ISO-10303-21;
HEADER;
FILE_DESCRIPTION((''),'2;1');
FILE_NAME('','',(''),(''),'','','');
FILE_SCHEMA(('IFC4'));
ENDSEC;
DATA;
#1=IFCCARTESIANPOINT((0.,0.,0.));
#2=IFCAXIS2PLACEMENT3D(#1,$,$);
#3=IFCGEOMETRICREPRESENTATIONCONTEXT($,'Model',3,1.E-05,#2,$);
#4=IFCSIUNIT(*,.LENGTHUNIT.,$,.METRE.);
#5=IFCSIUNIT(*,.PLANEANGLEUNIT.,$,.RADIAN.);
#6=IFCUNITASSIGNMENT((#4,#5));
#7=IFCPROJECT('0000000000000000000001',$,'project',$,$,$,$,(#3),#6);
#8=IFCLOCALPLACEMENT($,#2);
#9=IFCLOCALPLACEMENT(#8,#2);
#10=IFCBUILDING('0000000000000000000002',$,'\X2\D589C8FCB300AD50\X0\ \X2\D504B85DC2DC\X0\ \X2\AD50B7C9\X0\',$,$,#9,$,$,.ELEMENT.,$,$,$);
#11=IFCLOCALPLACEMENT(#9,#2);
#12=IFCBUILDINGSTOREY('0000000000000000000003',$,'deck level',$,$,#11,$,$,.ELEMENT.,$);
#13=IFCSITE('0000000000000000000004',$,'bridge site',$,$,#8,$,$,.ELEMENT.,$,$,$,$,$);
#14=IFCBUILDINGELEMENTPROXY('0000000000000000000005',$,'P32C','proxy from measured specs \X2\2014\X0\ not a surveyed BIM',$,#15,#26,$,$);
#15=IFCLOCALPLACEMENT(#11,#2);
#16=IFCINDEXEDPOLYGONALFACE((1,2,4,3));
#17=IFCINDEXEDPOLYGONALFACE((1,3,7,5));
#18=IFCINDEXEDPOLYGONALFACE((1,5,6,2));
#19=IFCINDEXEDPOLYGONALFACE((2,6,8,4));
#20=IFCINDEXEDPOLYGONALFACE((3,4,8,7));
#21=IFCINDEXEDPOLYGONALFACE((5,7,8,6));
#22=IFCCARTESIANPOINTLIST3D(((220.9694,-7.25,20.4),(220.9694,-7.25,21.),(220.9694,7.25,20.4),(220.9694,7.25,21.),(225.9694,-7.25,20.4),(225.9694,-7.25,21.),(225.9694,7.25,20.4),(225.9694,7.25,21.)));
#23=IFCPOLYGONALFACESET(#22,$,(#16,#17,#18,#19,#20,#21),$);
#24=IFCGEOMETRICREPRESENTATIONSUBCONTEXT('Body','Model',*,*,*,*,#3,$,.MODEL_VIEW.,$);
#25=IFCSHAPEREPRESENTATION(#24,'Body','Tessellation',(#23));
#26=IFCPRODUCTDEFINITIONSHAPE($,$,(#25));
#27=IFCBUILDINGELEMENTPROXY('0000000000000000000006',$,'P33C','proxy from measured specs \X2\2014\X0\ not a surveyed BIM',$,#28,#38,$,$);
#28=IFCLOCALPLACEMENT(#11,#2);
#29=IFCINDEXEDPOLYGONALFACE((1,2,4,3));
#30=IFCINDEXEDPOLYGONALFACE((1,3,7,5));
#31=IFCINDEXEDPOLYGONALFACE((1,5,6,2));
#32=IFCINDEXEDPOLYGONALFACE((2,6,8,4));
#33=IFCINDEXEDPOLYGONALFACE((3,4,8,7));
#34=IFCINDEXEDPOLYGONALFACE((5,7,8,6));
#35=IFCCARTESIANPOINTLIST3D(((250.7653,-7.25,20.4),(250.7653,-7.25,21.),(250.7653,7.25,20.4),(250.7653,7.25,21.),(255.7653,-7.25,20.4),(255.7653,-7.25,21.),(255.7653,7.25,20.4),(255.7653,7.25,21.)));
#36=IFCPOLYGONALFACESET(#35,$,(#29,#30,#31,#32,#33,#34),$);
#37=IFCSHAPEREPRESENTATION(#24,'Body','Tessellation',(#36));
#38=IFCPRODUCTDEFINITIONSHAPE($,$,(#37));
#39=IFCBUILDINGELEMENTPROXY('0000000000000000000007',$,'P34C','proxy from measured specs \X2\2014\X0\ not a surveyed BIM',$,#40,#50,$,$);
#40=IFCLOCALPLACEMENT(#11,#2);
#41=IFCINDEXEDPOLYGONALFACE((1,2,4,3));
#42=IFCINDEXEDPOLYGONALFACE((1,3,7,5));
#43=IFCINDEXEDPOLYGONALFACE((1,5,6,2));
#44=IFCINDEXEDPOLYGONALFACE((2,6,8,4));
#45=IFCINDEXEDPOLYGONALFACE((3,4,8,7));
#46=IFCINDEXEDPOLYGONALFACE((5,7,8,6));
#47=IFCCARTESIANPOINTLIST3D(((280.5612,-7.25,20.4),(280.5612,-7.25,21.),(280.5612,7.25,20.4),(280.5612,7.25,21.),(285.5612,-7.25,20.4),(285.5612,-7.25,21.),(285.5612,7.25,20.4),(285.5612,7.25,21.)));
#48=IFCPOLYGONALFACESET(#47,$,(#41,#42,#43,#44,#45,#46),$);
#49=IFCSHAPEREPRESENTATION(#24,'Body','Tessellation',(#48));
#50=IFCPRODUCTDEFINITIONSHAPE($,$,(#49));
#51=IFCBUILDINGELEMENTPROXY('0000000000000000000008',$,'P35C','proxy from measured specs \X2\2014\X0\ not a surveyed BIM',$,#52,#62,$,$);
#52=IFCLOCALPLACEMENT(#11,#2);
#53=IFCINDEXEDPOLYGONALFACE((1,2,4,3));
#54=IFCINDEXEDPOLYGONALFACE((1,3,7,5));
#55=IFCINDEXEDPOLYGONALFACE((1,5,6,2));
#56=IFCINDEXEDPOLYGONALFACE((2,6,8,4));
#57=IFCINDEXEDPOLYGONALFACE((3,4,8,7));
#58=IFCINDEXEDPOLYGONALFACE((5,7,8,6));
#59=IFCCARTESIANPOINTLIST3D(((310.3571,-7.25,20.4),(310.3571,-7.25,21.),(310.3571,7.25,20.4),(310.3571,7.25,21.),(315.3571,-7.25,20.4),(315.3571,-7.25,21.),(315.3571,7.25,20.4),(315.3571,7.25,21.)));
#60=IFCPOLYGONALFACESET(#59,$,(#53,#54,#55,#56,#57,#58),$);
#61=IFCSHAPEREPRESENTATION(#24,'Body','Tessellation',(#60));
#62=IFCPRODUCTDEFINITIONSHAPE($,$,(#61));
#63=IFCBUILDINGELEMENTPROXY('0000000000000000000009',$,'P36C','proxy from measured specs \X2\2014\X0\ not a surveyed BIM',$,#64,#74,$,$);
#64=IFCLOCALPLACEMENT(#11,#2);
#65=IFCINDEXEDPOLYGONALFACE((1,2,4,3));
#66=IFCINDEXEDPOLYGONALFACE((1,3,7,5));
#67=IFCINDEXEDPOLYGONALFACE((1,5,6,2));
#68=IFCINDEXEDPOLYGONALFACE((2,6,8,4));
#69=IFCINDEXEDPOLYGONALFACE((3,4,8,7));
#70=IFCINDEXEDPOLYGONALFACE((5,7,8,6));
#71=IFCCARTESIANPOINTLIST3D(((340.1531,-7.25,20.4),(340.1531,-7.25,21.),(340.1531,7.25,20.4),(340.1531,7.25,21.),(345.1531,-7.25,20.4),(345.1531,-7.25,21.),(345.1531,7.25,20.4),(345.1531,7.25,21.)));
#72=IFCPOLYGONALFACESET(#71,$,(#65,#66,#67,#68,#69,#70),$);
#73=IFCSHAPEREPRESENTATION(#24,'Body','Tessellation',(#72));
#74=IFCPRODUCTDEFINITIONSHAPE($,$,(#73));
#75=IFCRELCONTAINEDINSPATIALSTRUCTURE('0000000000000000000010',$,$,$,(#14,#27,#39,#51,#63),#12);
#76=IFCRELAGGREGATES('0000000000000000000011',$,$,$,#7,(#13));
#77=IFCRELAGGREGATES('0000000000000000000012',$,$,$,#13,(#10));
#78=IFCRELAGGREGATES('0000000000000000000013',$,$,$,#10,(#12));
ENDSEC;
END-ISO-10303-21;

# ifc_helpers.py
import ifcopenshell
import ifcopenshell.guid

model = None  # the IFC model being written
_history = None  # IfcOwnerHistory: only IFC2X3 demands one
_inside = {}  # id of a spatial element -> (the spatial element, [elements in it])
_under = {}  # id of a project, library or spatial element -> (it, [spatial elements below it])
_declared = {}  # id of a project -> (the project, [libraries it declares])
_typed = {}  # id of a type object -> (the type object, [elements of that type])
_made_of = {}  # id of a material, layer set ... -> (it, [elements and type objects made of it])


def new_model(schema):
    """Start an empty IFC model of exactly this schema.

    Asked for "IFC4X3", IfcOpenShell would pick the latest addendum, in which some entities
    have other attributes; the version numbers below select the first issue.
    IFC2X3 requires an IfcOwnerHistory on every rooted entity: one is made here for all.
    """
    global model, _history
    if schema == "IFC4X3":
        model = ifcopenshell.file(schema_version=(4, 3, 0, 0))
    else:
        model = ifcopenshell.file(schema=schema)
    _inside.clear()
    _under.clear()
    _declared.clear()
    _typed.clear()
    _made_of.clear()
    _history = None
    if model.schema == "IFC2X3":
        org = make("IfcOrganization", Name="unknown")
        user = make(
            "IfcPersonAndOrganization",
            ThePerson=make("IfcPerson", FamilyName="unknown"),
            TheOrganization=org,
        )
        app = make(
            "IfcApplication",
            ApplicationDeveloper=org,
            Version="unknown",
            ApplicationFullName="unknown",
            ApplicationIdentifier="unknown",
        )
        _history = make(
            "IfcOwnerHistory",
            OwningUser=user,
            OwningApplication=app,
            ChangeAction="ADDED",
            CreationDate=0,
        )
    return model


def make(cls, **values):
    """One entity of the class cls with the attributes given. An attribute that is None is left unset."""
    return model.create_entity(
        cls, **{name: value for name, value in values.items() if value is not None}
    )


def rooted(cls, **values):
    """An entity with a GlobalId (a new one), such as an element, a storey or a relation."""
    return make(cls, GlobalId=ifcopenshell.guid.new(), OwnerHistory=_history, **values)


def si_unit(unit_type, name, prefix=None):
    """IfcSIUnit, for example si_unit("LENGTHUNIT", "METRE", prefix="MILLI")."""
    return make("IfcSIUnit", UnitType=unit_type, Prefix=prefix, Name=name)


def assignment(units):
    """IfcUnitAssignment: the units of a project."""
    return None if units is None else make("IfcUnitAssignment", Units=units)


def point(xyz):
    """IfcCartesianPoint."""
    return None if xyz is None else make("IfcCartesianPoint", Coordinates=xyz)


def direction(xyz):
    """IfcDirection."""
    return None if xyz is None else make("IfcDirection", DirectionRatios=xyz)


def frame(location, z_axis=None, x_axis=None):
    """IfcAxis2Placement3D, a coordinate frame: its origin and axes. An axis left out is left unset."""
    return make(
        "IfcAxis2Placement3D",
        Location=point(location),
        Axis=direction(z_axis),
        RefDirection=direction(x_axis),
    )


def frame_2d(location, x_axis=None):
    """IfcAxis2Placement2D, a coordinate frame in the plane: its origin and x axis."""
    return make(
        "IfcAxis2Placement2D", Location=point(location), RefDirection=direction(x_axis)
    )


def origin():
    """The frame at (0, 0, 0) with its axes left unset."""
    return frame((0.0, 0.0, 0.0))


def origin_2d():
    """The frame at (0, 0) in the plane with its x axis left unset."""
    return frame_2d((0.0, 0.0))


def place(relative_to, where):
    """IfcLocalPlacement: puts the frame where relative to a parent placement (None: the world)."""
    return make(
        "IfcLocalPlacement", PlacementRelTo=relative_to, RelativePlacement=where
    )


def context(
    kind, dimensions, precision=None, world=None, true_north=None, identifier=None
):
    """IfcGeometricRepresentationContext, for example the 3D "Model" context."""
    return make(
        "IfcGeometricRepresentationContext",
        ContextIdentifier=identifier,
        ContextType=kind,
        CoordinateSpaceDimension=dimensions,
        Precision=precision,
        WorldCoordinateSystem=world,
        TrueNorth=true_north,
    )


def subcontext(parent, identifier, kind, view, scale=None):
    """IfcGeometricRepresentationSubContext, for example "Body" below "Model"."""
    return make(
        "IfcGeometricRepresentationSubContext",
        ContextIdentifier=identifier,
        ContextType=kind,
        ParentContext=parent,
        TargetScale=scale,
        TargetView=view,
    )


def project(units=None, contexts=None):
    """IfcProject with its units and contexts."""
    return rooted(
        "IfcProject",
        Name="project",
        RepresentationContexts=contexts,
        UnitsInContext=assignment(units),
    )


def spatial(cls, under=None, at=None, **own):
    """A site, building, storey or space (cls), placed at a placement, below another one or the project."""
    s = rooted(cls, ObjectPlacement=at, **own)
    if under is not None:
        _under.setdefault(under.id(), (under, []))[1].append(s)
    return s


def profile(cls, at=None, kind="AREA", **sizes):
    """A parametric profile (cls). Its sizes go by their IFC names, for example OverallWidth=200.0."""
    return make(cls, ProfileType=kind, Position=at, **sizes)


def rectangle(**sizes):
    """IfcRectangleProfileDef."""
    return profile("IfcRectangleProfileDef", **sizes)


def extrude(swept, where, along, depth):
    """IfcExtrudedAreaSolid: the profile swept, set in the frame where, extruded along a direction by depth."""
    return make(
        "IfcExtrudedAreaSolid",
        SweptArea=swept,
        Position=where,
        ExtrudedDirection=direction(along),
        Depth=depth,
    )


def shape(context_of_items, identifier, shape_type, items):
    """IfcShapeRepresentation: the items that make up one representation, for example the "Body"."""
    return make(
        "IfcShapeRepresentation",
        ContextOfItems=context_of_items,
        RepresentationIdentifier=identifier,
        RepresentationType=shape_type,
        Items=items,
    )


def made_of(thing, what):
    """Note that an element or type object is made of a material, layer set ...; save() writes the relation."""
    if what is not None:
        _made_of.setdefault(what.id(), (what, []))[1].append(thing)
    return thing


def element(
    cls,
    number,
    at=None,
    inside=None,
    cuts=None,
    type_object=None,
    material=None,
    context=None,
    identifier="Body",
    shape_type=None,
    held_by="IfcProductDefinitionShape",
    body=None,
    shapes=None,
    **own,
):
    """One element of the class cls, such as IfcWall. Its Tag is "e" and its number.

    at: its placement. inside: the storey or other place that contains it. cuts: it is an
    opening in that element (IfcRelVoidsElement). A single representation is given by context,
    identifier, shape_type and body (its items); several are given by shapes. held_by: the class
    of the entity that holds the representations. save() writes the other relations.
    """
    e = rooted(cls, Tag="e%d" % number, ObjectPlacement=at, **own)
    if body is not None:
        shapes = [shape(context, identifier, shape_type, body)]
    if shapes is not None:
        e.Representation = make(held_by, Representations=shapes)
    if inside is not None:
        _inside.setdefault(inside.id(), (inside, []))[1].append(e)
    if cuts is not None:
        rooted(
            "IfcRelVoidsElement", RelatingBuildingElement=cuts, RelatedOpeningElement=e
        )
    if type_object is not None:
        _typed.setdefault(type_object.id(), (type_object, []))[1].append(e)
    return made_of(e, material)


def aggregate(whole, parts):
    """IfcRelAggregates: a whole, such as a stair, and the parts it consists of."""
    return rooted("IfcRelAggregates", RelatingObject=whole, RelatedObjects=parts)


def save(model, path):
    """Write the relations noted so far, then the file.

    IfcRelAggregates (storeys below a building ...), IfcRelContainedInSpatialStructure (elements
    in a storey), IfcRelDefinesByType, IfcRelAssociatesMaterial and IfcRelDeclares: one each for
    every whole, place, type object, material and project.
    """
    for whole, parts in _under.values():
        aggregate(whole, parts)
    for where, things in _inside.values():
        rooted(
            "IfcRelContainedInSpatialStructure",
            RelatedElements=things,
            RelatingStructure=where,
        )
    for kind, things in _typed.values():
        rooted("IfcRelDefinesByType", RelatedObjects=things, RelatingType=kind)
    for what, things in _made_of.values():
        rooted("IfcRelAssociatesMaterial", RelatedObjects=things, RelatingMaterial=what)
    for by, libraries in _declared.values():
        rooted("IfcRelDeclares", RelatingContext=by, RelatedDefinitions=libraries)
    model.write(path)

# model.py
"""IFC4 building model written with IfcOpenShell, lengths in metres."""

from ifc_helpers import new_model, si_unit, frame, origin, origin_2d, place, context, subcontext, project, spatial, rectangle, extrude, element, save


model = new_model("IFC4")

# Units and contexts
model_context = context("Model", 3, precision=1e-05, world=origin())
body_context = subcontext(model_context, "Body", "Model", "MODEL_VIEW")
ifc_project = project(units=[si_unit("LENGTHUNIT", "METRE"), si_unit("PLANEANGLEUNIT", "RADIAN")], contexts=[model_context])

# Site, building, storey
site_placement = place(None, origin())
site = spatial("IfcSite", under=ifc_project, at=site_placement, Name="bridge site", CompositionType="ELEMENT")
building_placement = place(site_placement, origin())
building = spatial("IfcBuilding", under=site, at=building_placement, Name="행주대교 프록시 교량", CompositionType="ELEMENT")
storey_placement = place(building_placement, origin())
storey = spatial("IfcBuildingStorey", under=building, at=storey_placement, Name="deck level", CompositionType="ELEMENT")

# Building element proxies
for number, where, name in (
    (1, (223.4694, 0.0, 20.4), "P32C"),
    (2, (253.2653, 0.0, 20.4), "P33C"),
    (3, (283.0612, 0.0, 20.4), "P34C"),
    (4, (312.8571, 0.0, 20.4), "P35C"),
    (5, (342.6531, 0.0, 20.4), "P36C"),
):
    element("IfcBuildingElementProxy", number, at=place(storey_placement, frame(where)), inside=storey, Name=name, Description="proxy from measured specs — not a surveyed BIM", context=body_context, shape_type="SweptSolid", body=[
        extrude(rectangle(XDim=5.0, YDim=14.5, at=origin_2d()), origin(), (0.0, 0.0, 1.0), 0.6),
    ])

save(model, "model.ifc")
